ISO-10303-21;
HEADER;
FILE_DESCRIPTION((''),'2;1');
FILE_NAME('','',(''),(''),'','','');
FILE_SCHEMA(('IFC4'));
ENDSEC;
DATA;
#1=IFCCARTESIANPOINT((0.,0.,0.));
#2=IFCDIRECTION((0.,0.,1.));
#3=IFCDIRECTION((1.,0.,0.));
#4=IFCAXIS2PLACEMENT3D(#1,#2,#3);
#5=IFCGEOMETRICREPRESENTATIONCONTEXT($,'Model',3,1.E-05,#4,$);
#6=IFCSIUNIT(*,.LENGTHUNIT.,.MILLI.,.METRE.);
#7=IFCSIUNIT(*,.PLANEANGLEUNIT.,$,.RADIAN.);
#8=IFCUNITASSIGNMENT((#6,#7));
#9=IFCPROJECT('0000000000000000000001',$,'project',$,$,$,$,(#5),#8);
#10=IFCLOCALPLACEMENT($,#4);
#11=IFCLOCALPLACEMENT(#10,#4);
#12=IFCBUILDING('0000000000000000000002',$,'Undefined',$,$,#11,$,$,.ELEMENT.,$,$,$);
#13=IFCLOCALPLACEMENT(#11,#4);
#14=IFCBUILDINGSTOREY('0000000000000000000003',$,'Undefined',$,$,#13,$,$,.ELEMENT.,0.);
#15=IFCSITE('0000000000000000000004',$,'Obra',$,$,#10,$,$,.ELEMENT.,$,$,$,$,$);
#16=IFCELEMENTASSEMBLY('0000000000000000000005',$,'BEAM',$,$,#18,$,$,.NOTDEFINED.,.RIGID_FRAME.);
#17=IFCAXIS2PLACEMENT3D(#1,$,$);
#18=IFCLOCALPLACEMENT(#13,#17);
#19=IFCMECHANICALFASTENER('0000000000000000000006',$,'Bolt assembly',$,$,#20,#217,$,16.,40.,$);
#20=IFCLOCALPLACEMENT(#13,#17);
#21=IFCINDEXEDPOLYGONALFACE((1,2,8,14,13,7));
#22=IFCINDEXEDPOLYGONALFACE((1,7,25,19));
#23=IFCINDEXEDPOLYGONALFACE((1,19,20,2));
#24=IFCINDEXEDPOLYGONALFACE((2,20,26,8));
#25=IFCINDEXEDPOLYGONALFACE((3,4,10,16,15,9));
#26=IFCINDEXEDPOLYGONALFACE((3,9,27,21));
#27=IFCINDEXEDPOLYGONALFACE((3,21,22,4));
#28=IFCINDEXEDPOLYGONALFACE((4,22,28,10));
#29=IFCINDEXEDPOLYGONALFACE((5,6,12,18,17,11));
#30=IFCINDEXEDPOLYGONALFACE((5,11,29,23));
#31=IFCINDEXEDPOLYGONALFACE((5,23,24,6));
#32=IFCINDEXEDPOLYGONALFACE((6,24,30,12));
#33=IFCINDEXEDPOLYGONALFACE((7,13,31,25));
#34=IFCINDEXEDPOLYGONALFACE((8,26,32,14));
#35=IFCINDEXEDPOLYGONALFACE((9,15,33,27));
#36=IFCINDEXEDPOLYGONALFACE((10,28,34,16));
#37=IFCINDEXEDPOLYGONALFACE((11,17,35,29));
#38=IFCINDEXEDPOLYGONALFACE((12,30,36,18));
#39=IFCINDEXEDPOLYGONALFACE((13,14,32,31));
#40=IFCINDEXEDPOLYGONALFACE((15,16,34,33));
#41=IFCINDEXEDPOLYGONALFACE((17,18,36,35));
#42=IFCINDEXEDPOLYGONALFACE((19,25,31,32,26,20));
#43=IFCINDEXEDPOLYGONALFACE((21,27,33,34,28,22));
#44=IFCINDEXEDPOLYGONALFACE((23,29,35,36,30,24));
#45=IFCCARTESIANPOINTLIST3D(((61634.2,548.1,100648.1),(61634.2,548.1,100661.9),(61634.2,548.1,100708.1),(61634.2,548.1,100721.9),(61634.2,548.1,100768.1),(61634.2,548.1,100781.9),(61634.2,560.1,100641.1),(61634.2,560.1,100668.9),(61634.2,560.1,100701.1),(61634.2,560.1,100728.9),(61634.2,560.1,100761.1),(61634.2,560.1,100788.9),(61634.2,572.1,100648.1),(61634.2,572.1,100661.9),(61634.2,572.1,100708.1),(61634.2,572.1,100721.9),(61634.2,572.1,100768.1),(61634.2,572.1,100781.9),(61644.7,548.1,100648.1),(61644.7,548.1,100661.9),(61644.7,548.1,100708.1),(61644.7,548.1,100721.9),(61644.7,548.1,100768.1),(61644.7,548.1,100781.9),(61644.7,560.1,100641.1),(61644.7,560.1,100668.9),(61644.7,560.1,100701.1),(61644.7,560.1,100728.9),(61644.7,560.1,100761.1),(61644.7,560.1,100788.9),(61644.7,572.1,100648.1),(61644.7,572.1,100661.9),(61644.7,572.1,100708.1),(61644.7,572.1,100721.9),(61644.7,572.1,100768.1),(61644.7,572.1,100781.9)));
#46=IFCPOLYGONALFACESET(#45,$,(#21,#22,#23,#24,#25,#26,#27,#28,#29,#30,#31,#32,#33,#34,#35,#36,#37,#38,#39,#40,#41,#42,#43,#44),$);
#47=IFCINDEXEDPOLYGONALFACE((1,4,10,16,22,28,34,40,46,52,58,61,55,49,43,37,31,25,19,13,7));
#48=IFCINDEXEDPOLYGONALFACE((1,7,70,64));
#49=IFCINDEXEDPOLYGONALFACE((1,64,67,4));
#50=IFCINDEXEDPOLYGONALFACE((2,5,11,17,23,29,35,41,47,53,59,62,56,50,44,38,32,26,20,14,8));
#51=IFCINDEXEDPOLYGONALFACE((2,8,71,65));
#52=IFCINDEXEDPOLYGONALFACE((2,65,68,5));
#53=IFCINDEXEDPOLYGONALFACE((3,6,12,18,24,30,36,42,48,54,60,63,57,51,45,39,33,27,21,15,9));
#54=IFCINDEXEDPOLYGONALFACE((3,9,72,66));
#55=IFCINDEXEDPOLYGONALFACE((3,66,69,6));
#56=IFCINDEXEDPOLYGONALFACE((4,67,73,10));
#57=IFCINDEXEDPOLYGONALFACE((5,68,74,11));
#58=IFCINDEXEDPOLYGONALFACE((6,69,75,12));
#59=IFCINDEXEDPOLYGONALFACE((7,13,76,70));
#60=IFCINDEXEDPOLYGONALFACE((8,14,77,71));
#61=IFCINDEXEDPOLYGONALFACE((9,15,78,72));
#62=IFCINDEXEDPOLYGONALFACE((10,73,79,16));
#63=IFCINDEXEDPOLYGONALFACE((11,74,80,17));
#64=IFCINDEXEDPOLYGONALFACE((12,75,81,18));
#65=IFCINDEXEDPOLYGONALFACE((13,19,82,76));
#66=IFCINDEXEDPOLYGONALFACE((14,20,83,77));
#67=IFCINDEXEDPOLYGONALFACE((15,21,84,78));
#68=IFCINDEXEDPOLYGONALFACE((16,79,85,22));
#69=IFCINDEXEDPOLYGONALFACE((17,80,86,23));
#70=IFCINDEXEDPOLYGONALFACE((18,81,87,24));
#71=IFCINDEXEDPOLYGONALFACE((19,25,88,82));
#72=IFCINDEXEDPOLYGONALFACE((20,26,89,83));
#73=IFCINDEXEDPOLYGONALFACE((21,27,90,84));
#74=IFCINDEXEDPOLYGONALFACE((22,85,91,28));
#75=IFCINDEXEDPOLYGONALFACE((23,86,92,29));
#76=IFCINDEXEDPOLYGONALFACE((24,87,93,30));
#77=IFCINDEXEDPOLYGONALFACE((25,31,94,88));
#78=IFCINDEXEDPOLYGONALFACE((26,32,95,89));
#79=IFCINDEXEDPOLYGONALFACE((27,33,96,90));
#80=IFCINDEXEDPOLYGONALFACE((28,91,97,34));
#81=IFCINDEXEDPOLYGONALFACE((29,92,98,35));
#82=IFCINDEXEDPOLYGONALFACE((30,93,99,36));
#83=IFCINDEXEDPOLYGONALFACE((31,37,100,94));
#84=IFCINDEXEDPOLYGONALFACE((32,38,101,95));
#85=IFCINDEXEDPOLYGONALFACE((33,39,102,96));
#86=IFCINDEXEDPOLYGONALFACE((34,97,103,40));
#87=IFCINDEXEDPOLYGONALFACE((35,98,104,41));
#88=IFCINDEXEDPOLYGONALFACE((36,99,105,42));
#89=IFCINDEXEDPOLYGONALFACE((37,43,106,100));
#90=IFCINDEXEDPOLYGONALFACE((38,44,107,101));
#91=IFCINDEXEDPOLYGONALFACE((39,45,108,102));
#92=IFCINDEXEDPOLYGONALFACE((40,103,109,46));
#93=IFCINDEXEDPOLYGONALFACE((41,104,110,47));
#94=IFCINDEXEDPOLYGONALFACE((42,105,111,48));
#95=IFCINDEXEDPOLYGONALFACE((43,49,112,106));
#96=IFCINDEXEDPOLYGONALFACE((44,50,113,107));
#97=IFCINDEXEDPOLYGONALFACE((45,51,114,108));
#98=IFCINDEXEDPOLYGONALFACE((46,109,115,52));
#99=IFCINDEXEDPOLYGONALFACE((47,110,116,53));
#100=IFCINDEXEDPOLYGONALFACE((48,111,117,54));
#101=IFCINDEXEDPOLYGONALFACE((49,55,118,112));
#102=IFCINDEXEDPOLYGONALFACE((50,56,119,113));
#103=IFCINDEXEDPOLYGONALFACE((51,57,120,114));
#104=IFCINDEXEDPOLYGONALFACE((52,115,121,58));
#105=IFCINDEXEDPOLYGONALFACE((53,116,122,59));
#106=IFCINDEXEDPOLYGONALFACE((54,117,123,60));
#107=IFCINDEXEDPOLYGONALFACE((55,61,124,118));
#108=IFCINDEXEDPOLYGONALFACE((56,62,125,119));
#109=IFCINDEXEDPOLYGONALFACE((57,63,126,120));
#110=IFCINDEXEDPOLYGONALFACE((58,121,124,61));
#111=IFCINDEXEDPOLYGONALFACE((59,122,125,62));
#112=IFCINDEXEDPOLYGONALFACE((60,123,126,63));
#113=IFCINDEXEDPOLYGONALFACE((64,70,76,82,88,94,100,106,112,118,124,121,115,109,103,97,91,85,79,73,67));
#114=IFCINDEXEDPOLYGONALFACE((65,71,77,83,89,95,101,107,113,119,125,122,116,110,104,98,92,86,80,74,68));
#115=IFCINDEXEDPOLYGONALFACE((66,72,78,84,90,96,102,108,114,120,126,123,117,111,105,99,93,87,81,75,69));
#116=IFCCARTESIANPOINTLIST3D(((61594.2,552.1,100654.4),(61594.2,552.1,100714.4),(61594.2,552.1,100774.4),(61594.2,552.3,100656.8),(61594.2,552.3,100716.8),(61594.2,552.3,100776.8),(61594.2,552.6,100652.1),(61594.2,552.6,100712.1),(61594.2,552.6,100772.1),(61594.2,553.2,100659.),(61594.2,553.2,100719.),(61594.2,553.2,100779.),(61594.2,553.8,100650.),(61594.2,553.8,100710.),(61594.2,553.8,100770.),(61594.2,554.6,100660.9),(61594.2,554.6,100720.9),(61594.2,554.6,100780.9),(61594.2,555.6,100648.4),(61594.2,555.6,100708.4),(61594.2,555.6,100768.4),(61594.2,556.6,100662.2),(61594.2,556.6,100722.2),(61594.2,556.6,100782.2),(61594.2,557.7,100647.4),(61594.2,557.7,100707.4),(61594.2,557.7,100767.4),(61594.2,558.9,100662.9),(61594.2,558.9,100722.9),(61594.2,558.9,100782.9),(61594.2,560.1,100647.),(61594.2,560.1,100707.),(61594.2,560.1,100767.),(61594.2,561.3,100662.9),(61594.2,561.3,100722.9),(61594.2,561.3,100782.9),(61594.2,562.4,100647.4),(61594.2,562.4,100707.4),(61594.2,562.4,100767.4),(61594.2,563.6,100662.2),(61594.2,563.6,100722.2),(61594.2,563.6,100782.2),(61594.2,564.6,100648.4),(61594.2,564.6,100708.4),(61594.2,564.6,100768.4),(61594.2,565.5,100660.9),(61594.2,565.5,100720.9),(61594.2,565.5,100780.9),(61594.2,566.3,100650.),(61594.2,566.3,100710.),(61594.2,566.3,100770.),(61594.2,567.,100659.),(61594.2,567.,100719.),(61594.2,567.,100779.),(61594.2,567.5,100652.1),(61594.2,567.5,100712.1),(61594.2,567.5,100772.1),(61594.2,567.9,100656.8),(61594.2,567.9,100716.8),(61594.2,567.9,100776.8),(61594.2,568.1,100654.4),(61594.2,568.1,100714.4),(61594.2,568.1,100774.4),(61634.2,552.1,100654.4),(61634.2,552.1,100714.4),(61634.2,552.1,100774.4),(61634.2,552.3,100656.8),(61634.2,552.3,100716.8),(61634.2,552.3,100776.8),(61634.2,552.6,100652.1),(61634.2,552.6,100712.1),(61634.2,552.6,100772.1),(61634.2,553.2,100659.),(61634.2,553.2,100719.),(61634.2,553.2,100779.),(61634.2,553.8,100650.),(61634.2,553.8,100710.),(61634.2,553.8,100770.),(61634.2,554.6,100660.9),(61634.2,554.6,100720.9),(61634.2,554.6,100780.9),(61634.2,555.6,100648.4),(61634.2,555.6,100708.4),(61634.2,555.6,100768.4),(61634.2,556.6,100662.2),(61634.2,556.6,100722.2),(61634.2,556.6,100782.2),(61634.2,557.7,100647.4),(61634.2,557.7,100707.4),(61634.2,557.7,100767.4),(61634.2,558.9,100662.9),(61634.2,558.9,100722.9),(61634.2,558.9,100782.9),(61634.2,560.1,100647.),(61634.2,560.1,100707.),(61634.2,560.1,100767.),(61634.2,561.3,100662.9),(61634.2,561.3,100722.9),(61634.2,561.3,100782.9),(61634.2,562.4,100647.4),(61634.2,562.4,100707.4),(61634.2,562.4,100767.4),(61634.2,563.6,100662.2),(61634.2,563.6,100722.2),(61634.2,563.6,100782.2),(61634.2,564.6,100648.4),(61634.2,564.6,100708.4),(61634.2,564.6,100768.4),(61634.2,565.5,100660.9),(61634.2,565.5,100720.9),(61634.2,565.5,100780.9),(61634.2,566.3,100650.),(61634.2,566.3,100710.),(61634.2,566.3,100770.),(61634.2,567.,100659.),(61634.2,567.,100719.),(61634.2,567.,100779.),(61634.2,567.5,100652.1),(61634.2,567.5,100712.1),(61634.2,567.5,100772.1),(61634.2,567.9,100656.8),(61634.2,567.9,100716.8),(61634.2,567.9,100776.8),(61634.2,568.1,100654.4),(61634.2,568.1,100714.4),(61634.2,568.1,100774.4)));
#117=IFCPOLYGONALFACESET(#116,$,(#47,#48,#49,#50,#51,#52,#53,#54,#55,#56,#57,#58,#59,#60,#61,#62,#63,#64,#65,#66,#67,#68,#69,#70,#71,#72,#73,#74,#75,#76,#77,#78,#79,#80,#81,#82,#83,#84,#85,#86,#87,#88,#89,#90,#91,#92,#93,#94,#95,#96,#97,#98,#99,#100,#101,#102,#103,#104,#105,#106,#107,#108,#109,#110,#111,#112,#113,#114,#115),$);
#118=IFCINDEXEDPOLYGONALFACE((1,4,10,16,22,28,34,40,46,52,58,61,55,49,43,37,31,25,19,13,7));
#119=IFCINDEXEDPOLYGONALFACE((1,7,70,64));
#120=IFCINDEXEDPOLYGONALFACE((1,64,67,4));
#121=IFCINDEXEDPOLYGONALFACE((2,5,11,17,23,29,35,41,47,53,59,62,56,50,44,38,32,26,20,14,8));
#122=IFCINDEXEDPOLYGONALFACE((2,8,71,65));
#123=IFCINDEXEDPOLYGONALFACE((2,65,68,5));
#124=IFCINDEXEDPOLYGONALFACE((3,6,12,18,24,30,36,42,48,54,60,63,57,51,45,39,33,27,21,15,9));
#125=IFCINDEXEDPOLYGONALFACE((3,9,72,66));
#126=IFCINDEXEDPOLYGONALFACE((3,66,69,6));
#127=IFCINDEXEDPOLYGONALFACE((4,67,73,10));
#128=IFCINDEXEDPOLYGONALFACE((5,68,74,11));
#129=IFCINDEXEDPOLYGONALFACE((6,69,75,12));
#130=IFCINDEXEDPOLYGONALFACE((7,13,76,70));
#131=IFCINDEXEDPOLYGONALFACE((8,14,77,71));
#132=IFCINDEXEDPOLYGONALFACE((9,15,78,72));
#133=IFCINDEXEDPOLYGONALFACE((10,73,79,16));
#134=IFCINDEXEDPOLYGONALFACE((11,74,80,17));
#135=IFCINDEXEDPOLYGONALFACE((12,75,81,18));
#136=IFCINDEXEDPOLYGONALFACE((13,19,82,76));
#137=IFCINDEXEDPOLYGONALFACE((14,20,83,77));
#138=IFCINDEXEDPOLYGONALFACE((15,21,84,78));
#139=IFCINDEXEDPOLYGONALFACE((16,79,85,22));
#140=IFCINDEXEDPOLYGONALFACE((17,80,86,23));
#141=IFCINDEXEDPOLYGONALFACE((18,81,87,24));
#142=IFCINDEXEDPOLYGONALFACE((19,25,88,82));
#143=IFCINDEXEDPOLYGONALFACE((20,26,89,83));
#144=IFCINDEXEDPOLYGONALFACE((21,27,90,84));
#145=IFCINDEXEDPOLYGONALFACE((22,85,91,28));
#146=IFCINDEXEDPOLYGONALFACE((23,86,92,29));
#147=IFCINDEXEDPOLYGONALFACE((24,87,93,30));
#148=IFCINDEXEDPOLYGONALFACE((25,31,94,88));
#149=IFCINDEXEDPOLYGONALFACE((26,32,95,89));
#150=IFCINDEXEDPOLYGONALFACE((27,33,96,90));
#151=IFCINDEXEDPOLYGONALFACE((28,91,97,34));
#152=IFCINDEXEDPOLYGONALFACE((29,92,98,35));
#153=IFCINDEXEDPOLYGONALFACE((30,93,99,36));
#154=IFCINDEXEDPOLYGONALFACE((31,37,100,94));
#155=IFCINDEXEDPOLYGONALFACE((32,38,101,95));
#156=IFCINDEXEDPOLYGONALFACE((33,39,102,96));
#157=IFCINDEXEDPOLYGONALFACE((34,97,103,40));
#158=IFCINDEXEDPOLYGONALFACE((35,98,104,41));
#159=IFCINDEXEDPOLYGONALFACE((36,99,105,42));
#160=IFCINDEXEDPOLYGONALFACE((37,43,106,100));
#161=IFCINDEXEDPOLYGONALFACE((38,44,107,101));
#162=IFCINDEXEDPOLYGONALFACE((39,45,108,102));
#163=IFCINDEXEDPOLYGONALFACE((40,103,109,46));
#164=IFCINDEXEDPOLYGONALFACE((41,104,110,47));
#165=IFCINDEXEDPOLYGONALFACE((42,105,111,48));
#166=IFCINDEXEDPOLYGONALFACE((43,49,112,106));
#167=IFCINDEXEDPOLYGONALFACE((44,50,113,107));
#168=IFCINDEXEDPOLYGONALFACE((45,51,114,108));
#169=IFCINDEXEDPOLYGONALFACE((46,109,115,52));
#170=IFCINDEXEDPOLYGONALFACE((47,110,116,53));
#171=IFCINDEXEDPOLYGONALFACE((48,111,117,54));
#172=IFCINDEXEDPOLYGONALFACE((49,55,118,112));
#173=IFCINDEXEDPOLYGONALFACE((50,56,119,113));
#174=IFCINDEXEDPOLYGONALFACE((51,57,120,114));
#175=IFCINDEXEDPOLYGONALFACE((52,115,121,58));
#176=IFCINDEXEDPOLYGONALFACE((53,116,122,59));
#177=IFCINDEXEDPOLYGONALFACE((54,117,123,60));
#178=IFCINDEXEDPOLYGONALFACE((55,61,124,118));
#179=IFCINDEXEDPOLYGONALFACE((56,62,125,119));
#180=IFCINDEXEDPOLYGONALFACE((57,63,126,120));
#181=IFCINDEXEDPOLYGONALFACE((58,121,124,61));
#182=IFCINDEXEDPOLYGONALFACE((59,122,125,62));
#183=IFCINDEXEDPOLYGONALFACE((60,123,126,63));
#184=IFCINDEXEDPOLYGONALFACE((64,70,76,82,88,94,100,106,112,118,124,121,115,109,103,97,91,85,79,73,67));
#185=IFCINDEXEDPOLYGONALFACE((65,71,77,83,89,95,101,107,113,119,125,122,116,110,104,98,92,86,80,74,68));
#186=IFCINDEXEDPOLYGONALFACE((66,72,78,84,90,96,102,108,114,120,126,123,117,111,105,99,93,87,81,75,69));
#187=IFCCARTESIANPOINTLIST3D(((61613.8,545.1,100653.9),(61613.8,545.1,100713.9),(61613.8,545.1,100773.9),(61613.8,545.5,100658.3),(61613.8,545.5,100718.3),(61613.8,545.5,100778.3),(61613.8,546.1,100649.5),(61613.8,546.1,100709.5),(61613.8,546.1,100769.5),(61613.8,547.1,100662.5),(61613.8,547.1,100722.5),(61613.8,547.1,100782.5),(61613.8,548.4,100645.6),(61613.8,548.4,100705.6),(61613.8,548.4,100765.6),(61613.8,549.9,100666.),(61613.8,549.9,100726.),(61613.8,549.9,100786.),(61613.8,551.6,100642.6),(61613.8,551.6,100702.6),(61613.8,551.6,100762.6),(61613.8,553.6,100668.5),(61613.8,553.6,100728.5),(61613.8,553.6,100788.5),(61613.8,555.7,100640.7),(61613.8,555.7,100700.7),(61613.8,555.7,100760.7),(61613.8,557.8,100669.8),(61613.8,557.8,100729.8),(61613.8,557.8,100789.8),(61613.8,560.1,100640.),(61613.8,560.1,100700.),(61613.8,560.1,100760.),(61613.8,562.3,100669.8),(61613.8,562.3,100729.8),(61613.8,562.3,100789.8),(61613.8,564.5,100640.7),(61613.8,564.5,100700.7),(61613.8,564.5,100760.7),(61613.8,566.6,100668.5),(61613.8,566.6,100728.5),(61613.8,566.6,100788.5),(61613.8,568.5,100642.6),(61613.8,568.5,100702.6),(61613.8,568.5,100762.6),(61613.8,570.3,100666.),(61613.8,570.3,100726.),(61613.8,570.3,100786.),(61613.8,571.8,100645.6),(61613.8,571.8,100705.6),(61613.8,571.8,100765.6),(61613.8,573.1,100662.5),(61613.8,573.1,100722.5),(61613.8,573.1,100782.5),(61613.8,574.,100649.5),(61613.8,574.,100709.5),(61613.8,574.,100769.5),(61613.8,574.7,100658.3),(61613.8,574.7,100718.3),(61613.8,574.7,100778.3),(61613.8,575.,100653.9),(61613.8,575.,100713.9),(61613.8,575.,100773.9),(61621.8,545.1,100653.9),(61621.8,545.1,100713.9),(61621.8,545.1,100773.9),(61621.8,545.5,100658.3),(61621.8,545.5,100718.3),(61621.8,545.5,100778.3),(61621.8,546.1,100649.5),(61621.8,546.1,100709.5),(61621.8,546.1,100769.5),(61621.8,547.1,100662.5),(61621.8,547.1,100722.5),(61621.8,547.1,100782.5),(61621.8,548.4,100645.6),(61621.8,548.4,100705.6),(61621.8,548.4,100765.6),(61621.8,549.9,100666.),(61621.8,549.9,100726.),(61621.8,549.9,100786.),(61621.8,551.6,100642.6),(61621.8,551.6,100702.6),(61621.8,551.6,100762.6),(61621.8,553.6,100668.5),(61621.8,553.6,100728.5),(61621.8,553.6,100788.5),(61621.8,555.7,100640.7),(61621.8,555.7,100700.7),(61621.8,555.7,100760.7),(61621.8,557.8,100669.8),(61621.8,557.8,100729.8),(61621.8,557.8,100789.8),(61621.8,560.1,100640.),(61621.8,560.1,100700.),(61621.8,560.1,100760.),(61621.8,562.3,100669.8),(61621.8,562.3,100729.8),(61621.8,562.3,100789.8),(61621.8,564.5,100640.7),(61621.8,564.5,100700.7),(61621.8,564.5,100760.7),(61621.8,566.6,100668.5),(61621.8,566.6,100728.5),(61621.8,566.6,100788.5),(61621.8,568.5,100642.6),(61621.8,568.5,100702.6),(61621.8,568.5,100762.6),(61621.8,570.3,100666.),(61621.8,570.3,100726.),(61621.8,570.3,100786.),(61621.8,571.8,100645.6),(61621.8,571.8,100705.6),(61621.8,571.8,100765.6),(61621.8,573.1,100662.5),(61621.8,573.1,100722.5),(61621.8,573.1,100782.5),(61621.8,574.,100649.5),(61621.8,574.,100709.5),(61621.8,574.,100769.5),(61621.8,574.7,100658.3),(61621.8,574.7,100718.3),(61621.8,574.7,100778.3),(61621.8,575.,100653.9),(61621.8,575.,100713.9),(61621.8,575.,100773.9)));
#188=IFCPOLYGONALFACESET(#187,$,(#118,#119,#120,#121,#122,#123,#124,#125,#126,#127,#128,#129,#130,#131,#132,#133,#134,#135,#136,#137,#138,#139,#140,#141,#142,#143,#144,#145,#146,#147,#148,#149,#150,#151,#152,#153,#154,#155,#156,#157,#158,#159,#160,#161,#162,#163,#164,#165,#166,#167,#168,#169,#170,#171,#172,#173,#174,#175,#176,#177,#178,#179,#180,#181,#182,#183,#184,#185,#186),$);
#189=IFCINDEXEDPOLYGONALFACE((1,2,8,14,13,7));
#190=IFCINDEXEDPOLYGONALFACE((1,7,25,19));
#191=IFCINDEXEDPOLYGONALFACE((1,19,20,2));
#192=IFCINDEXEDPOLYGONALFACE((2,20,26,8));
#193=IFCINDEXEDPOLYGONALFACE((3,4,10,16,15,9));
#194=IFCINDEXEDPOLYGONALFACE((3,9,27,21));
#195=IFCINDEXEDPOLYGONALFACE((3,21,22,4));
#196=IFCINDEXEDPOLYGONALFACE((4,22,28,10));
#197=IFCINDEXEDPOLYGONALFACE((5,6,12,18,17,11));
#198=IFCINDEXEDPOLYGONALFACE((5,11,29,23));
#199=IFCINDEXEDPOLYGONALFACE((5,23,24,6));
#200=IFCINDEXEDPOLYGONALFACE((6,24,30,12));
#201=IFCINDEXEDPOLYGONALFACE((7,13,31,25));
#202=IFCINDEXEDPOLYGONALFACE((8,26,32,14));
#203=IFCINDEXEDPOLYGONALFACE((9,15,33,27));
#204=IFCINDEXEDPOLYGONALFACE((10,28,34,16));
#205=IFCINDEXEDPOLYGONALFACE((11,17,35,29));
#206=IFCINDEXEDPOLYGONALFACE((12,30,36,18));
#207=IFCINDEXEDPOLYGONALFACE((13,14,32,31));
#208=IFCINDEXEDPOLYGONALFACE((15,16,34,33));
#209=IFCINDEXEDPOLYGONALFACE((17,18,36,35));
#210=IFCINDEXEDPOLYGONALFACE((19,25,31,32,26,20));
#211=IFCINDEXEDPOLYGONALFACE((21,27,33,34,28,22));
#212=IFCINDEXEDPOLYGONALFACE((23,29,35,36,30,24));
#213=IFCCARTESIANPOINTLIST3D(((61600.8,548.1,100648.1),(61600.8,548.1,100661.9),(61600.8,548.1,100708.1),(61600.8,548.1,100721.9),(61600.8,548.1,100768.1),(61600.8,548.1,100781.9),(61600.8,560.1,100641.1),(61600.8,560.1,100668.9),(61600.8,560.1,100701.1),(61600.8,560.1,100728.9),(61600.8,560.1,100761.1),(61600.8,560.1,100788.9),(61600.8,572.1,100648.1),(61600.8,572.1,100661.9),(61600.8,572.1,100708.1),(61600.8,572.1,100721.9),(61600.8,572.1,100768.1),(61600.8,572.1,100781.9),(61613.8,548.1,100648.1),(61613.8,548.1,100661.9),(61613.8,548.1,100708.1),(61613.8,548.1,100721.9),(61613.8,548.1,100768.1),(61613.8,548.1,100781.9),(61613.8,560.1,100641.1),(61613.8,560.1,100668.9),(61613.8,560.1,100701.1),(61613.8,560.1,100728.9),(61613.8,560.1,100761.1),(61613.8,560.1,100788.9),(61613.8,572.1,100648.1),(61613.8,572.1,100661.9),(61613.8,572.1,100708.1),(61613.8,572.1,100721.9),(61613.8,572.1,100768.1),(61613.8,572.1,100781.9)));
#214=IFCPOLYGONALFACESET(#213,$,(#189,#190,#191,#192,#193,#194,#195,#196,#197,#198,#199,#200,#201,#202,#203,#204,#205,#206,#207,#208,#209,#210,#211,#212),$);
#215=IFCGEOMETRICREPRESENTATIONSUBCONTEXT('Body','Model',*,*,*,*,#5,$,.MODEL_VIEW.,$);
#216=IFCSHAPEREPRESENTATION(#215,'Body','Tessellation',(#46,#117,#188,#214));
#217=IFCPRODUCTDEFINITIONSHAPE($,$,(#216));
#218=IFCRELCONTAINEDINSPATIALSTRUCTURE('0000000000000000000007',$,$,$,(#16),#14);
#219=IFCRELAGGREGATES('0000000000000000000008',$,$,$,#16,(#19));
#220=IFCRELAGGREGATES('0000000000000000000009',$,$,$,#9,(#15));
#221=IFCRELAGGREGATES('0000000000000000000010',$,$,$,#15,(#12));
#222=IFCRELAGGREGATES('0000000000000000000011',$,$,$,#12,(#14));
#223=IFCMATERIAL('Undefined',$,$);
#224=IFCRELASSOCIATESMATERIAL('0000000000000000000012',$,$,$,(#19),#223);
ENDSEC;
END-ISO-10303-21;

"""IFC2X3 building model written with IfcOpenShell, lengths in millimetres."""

from ifc_helpers import new_model, si_unit, frame, origin_with_axes, origin_2d_with_axis, place, context, subcontext, project, spatial, polyline, circle, outline, extrude, source, transform, mapped, material, element, aggregate, save


model = new_model("IFC2X3")

# Units and contexts
model_context = context("Model", 3, precision=1e-05, world=origin_with_axes())
body_context = subcontext(model_context, "Body", "Model", "MODEL_VIEW")
ifc_project = project(units=[si_unit("LENGTHUNIT", "METRE", prefix="MILLI"), si_unit("PLANEANGLEUNIT", "RADIAN")], contexts=[model_context])

# Site, building, storey
site_placement = place(None, origin_with_axes())
site = spatial("IfcSite", under=ifc_project, at=site_placement, Name="Obra", CompositionType="ELEMENT")
building_placement = place(site_placement, origin_with_axes())
building = spatial("IfcBuilding", under=site, at=building_placement, Name="Undefined", CompositionType="ELEMENT")
storey_placement = place(building_placement, origin_with_axes())
storey = spatial("IfcBuildingStorey", under=building, at=storey_placement, Name="Undefined", CompositionType="ELEMENT", Elevation=0.0)

# Shared definitions
ifc_material_1 = material(Name="Undefined")

# Element assembly, mechanical fastener
shared_shape_1 = source(origin_with_axes(), body_context, "Body", "SweptSolid", [
    extrude(outline(polyline([(13.9, 0.0), (6.9, 12.0), (-6.9, 12.0), (-13.9, 0.0), (-6.9, -12.0), (6.9, -12.0), (13.9, 0.0)])), frame((0.0, -19.7, 0.0), z_axis=(0.0, 1.0, 0.0), x_axis=(1.0, 0.0, 0.0)), (0.0, 0.0, 1.0), 10.6),
    extrude(circle(Radius=8.0, at=origin_2d_with_axis()), frame((0.0, -9.1, 0.0), z_axis=(0.0, 1.0, 0.0), x_axis=(1.0, 0.0, 0.0)), (0.0, 0.0, 1.0), 40.0),
    extrude(circle(Radius=15.0, at=origin_2d_with_axis()), frame((0.0, 3.3, 0.0), z_axis=(0.0, 1.0, 0.0), x_axis=(1.0, 0.0, 0.0)), (0.0, 0.0, 1.0), 8.0),
    extrude(outline(polyline([(13.9, 0.0), (6.9, 12.0), (-6.9, 12.0), (-13.9, 0.0), (-6.9, -12.0), (6.9, -12.0), (13.9, 0.0)])), frame((0.0, 11.3, 0.0), z_axis=(0.0, 1.0, 0.0), x_axis=(1.0, 0.0, 0.0)), (0.0, 0.0, 1.0), 13.0),
])
assembly_1_placement = place(storey_placement, origin_with_axes())
assembly_1 = element("IfcElementAssembly", 1, at=assembly_1_placement, inside=storey, Name="BEAM", AssemblyPlace="NOTDEFINED", PredefinedType="RIGID_FRAME")
mechanical_fastener_1_placement = place(assembly_1_placement, frame((61625.1, 510.1, 100835.0), z_axis=(-0.000002, 1.0, 0.0), x_axis=(0.0, 0.0, -1.0)))
mechanical_fastener_1 = element("IfcMechanicalFastener", 2, at=mechanical_fastener_1_placement, material=ifc_material_1, Name="Bolt assembly", NominalDiameter=16.0, NominalLength=40.0, context=body_context, shape_type="MappedRepresentation", body=[
    mapped(shared_shape_1, transform((60.0, 0.0, 50.0))),
    mapped(shared_shape_1, transform((120.0, 0.0, 50.0))),
    mapped(shared_shape_1, transform((180.0, 0.0, 50.0))),
])

aggregate(assembly_1, [mechanical_fastener_1])

save(model, "model.ifc")
